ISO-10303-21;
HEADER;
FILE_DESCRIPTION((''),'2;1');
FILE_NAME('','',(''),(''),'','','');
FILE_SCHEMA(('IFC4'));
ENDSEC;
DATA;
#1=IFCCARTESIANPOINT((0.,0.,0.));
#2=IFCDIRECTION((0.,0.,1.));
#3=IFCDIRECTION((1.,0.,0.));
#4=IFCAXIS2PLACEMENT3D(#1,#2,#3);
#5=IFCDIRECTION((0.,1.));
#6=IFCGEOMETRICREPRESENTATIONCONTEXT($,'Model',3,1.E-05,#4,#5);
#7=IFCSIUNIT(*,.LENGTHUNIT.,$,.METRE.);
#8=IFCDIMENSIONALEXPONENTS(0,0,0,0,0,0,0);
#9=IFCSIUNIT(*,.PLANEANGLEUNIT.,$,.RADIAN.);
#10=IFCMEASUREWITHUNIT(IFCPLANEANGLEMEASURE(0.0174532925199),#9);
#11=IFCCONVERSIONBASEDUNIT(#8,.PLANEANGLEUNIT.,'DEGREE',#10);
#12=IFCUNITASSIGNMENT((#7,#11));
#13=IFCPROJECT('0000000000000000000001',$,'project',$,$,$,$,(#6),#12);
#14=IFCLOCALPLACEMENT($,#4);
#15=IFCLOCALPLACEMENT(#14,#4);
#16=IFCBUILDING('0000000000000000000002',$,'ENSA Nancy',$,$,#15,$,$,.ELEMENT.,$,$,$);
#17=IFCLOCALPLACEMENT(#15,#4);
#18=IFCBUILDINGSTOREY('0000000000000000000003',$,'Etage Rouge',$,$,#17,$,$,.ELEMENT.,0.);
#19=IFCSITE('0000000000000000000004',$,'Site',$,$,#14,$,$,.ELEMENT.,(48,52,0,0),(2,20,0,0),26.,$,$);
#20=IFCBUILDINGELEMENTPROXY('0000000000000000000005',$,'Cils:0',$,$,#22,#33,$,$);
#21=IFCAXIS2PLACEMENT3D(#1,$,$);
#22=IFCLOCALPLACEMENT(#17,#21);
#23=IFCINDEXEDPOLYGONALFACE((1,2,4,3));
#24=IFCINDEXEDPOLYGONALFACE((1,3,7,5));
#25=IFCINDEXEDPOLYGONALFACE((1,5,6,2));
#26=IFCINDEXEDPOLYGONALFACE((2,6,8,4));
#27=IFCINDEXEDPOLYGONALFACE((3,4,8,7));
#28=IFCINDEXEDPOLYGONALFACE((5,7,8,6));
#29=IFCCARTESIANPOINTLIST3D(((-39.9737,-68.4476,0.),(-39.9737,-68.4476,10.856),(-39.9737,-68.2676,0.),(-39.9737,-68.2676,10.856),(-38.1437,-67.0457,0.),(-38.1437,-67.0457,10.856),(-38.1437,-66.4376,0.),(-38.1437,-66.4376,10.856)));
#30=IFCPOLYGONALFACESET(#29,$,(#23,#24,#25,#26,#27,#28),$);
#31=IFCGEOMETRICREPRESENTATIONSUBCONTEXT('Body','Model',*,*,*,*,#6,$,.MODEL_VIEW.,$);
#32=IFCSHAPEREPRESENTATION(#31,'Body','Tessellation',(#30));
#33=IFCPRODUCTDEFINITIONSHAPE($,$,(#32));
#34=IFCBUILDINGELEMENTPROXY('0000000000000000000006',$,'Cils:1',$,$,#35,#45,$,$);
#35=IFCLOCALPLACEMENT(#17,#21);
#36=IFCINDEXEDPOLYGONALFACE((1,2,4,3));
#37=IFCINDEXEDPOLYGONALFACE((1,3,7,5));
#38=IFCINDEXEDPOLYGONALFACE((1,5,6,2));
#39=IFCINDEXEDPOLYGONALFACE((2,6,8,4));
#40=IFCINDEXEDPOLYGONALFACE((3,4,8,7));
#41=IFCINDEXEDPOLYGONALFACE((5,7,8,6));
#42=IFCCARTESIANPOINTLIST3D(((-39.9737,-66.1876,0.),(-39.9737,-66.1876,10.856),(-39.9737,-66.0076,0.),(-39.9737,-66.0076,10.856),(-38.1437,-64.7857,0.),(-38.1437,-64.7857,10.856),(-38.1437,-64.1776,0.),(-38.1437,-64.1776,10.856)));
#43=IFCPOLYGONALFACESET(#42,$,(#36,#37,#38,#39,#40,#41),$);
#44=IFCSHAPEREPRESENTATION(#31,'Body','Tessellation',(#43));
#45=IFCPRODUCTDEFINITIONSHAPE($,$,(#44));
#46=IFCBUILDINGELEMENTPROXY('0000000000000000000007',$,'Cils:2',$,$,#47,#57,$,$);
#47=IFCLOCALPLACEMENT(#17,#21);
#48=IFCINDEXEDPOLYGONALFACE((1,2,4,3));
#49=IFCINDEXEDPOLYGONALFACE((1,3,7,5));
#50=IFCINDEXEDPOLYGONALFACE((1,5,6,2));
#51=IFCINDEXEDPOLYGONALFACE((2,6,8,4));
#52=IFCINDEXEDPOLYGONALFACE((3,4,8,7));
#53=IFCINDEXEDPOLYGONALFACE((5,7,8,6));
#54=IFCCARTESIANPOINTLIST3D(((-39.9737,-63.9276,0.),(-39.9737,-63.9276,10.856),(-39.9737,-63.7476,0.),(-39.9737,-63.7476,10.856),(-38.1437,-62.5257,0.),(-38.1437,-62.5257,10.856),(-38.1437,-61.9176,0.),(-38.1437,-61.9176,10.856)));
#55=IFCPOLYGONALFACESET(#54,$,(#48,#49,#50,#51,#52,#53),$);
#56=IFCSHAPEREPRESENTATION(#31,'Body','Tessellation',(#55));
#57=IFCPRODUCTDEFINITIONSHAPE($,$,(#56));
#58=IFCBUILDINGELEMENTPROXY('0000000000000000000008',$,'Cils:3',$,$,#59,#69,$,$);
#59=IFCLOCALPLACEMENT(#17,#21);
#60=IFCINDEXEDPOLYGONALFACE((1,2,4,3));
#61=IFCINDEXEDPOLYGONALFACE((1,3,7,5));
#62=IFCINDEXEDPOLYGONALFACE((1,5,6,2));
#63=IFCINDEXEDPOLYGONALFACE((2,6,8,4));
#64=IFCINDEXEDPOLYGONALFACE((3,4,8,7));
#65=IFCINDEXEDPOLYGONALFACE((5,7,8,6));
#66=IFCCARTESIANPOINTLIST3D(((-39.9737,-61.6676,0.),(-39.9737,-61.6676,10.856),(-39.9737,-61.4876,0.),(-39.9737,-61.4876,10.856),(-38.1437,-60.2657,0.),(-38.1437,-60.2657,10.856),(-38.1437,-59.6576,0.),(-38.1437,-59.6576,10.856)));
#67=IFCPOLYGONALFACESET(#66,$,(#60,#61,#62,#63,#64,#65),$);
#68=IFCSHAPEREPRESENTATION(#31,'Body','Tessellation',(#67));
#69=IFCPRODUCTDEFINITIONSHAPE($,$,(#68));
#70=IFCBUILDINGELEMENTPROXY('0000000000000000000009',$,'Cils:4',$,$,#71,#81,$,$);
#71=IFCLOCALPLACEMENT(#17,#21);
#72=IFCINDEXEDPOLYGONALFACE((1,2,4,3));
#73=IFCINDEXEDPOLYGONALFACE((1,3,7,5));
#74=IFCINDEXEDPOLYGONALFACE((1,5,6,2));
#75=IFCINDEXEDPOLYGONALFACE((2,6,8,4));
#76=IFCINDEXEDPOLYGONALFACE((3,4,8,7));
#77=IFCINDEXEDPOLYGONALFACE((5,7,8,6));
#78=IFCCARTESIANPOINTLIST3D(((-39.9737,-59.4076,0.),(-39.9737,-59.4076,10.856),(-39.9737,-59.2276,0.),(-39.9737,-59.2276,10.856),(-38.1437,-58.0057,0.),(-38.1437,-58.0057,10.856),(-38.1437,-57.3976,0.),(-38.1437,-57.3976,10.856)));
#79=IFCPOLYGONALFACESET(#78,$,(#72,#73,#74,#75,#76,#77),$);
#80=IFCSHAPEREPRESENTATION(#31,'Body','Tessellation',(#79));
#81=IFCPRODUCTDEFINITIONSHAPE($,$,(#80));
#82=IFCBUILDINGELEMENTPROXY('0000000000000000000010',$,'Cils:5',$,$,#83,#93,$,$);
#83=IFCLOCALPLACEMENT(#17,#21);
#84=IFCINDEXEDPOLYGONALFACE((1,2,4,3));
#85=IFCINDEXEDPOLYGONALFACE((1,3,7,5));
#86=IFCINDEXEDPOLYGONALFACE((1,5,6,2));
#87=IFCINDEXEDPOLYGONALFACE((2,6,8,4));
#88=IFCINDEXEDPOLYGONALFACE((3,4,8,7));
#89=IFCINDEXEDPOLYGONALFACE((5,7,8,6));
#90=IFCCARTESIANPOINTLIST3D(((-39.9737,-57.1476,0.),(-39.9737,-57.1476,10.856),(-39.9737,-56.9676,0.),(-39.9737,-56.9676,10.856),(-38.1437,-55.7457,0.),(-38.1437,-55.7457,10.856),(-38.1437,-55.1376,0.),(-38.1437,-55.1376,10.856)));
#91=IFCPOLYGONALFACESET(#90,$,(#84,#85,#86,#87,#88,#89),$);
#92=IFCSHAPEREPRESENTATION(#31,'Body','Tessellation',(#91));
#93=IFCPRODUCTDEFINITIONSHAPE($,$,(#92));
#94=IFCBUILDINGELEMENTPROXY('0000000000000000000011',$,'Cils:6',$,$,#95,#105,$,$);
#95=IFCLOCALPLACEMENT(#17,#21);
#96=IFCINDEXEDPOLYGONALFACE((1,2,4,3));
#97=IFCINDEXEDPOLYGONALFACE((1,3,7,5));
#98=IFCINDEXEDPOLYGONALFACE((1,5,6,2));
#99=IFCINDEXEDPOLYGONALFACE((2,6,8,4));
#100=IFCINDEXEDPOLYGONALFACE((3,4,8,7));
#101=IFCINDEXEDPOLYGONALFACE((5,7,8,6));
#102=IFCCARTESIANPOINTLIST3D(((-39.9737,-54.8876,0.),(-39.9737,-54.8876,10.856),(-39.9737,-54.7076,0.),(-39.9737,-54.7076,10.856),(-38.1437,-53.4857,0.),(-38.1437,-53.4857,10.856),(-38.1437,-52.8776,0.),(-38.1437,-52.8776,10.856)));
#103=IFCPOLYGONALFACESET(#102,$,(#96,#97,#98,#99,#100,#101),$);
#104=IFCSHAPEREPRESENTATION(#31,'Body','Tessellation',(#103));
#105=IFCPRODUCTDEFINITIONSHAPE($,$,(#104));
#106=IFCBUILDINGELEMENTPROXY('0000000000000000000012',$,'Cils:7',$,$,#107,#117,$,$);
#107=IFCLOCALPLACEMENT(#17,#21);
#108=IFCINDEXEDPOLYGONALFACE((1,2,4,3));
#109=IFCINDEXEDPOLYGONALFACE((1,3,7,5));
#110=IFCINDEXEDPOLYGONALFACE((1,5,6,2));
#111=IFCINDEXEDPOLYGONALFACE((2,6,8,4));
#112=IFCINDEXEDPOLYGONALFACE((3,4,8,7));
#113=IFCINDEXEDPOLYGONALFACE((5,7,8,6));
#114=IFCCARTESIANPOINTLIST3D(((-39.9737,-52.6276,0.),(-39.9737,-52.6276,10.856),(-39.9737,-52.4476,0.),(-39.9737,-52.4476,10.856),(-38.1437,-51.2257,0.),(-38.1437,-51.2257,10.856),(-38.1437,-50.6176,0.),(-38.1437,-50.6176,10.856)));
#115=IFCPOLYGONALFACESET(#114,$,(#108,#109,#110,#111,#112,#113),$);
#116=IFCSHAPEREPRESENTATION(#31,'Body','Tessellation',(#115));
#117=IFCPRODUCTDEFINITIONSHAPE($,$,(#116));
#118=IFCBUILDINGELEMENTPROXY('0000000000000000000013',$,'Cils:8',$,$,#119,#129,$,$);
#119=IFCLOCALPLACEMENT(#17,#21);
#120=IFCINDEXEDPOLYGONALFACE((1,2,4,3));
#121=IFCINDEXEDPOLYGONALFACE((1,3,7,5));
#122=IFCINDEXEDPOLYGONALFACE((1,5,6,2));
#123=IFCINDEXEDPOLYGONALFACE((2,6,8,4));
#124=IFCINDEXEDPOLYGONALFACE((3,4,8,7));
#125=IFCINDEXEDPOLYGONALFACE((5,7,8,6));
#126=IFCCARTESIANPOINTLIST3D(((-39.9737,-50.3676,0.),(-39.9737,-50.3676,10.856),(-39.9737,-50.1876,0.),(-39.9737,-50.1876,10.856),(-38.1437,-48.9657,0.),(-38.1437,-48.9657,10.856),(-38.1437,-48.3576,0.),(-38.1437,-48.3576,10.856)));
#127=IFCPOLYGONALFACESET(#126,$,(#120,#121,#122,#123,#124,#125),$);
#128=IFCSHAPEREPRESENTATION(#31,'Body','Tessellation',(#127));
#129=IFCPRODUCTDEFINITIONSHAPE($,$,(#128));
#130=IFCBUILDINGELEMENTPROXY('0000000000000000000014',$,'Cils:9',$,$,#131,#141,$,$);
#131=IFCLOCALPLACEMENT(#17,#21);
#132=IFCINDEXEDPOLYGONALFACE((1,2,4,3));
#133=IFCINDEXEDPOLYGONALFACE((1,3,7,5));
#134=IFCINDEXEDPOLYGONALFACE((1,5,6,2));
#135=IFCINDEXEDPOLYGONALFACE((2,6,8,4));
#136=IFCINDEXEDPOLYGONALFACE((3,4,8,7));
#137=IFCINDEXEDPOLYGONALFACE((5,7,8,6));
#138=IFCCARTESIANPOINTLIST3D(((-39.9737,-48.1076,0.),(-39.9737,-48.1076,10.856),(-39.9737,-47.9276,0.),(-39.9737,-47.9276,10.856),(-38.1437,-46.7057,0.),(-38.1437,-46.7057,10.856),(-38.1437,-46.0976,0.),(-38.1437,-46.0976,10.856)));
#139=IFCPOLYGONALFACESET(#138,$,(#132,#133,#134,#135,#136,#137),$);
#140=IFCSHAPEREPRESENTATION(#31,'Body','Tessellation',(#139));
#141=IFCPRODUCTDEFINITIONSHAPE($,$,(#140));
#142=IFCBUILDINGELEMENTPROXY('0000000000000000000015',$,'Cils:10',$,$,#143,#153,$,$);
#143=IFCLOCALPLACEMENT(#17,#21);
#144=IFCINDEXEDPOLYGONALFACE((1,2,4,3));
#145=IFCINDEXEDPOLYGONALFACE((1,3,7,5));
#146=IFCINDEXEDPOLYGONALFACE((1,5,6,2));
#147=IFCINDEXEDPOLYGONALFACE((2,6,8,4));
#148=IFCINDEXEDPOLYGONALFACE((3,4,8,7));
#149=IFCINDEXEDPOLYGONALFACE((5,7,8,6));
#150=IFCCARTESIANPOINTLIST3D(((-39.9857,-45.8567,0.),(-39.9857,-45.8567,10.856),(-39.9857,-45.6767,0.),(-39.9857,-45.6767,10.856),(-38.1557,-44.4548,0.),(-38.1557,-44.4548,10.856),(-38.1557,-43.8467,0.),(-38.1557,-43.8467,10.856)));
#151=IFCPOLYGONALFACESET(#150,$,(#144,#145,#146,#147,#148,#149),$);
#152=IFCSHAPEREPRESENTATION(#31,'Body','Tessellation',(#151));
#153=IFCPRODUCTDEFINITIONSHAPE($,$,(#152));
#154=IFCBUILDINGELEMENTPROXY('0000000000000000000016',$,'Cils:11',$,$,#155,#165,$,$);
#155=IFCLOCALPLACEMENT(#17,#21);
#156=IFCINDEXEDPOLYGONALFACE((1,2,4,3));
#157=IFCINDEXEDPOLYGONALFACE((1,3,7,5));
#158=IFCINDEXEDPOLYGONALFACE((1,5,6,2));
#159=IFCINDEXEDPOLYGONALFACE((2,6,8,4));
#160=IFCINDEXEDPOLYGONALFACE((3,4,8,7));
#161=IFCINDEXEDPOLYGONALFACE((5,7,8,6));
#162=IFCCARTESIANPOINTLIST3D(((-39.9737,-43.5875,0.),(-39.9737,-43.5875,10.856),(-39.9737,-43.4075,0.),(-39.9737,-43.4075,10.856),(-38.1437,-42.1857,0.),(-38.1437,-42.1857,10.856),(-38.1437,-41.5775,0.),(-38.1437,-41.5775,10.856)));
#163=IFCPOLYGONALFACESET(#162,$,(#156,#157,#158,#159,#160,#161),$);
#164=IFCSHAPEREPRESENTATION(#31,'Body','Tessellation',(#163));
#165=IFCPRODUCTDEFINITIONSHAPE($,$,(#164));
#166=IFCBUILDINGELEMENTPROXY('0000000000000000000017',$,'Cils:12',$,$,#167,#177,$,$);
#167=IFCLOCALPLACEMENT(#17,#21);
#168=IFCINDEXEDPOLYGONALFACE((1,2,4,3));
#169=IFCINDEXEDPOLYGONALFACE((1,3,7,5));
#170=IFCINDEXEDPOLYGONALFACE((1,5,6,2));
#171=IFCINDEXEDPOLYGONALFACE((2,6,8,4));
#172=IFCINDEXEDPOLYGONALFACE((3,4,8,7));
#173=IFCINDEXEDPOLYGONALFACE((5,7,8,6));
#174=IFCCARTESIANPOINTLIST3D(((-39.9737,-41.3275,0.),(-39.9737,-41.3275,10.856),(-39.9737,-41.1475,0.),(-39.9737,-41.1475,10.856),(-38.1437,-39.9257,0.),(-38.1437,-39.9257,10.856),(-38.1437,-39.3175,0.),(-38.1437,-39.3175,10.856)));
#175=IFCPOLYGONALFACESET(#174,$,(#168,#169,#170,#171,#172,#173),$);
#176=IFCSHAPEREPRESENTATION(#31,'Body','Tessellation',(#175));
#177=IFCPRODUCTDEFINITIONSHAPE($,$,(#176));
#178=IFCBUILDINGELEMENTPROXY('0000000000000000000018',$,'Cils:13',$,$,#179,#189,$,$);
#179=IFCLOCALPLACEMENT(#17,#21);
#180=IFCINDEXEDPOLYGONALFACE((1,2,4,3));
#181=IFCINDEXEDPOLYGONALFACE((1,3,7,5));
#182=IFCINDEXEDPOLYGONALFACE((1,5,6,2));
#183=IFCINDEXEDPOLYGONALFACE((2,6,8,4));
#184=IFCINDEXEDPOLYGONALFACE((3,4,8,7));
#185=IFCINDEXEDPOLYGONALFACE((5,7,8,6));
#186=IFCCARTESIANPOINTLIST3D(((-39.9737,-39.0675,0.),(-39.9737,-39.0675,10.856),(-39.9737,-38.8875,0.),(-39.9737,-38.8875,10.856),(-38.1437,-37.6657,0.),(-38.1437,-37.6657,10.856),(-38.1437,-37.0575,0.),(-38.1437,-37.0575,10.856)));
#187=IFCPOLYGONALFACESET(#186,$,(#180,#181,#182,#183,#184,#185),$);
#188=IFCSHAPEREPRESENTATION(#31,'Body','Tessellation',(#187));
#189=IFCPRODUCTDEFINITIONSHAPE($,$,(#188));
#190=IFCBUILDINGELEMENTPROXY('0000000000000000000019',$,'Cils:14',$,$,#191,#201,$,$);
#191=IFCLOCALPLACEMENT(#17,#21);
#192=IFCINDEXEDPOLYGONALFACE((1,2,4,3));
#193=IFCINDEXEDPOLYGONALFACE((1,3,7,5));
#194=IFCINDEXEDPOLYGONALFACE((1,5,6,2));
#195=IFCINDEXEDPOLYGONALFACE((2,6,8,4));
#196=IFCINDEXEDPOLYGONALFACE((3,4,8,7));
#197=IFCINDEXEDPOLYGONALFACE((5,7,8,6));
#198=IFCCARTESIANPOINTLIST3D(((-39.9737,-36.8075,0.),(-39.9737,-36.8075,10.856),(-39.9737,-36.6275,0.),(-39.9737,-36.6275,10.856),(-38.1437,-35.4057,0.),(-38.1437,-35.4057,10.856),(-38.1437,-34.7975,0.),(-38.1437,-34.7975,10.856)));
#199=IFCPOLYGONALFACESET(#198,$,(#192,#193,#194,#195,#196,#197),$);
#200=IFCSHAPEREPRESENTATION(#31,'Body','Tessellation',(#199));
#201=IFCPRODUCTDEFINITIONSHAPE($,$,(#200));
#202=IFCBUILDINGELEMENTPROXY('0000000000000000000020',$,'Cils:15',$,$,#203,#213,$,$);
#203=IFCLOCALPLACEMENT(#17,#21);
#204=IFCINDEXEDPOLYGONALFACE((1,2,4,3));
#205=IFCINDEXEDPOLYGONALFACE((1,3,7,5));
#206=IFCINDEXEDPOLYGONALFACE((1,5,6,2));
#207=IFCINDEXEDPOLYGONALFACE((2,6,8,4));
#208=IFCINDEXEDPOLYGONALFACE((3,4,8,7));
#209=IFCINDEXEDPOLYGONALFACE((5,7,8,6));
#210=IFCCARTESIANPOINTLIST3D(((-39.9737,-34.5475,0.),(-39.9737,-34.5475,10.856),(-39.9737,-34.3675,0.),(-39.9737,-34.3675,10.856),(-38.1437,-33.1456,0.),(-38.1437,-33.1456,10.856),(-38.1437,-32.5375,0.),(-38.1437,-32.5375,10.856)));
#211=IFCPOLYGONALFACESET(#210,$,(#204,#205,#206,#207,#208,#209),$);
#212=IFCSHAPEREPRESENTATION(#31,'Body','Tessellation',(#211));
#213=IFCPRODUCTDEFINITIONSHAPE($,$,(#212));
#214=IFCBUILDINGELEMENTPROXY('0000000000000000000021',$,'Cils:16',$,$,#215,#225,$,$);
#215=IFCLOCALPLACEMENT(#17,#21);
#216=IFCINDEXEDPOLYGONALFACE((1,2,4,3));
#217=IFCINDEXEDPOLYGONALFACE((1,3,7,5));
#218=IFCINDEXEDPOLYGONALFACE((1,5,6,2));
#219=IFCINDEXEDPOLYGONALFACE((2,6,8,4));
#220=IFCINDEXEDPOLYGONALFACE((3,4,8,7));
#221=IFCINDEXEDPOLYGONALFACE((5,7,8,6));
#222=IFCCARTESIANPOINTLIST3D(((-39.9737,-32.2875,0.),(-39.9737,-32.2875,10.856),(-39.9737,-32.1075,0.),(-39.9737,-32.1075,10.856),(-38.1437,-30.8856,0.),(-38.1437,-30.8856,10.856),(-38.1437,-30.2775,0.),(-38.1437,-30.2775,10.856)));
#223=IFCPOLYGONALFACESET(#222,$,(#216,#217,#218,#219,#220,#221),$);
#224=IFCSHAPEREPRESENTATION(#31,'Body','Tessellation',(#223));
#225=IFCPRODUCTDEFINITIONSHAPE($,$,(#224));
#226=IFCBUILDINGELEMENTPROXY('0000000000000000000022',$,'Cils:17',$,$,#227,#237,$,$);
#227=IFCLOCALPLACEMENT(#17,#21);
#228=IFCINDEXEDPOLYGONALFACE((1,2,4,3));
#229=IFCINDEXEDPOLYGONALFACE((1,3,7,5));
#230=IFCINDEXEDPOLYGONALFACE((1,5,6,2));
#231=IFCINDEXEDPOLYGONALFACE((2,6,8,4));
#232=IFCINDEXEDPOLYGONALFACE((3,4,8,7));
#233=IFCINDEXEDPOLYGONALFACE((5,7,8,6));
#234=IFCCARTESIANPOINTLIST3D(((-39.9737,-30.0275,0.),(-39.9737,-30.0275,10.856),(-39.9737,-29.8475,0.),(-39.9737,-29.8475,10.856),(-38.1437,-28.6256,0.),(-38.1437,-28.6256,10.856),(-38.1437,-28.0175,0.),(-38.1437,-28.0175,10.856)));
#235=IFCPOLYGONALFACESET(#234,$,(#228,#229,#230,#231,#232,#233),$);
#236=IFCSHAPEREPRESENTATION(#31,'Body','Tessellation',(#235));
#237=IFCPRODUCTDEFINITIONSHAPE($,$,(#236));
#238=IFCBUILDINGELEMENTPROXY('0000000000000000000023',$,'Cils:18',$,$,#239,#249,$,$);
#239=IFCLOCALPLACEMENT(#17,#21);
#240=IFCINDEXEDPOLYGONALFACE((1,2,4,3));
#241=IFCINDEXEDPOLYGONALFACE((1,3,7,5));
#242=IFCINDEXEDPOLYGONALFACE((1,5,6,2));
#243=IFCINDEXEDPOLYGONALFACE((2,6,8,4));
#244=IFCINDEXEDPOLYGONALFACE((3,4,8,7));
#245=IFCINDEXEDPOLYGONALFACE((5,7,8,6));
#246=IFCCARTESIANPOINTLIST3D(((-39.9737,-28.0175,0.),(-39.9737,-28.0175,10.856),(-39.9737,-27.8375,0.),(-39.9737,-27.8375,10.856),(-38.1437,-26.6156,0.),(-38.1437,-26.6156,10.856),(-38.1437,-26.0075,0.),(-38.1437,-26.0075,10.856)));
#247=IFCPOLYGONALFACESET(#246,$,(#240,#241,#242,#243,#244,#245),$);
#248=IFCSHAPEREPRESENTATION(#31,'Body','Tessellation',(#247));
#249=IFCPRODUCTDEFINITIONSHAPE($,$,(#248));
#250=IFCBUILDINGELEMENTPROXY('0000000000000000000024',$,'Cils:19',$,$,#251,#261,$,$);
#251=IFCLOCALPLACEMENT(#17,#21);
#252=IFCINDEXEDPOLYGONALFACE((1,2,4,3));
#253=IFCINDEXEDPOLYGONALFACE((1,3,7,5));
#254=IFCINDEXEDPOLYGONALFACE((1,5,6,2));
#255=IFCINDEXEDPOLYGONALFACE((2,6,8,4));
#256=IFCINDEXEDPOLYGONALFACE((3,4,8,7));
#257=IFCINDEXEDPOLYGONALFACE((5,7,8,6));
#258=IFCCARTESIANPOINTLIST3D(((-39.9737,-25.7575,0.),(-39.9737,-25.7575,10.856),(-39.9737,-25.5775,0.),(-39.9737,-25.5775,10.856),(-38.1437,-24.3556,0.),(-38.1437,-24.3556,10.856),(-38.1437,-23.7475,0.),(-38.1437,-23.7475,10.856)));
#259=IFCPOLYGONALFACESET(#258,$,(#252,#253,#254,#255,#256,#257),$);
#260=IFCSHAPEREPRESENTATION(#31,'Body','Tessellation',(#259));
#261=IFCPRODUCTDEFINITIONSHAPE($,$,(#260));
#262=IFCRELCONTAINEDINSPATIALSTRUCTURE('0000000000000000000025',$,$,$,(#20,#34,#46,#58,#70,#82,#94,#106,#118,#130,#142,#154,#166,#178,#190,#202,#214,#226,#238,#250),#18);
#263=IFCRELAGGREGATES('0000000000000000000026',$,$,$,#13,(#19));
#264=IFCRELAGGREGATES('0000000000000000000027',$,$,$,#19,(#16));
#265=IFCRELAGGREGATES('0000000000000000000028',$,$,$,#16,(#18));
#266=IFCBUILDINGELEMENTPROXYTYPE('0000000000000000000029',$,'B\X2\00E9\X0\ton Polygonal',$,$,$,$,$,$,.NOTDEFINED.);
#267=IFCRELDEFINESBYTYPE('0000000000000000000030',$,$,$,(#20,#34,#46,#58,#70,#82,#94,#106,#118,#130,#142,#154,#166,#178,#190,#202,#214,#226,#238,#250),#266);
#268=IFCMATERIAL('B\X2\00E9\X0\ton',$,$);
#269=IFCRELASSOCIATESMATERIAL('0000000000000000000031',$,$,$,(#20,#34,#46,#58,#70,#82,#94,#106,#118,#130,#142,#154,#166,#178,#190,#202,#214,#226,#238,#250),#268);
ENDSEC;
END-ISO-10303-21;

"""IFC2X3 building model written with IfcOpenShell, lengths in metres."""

from ifc_helpers import new_model, entity, si_unit, converted_unit, direction, frame, origin_with_axes, place, context, subcontext, project, spatial, polyline, outline, extrude, material, type_object, element, save


model = new_model("IFC2X3")

# Units and contexts
model_context = context("Model", 3, precision=1e-05, world=origin_with_axes(), true_north=direction((0.0, 1.0)))
body_context = subcontext(model_context, "Body", "Model", "MODEL_VIEW")
ifc_project = project(units=[si_unit("LENGTHUNIT", "METRE"), converted_unit("PLANEANGLEUNIT", "DEGREE", entity("IfcPlaneAngleMeasure", 0.0174532925199), si_unit("PLANEANGLEUNIT", "RADIAN"), dimensions=[0, 0, 0, 0, 0, 0, 0])], contexts=[model_context])

# Site, building, storey
site_placement = place(None, origin_with_axes())
site = spatial("IfcSite", under=ifc_project, at=site_placement, Name="Site", CompositionType="ELEMENT", RefLatitude=(48, 52, 0, 0), RefLongitude=(2, 20, 0, 0), RefElevation=26.0)
building_placement = place(site_placement, origin_with_axes())
building = spatial("IfcBuilding", under=site, at=building_placement, Name="ENSA Nancy", CompositionType="ELEMENT")
storey_placement = place(building_placement, origin_with_axes())
storey = spatial("IfcBuildingStorey", under=building, at=storey_placement, Name="Etage Rouge", CompositionType="ELEMENT", Elevation=0.0)

# Building element proxies
ifc_material = material(Name="Béton")
building_element_proxy_type = type_object("IfcBuildingElementProxyType", Name="Béton Polygonal", PredefinedType="NOTDEFINED")
for number, where, z_axis, x_axis, name in (
    (1, (-38.1437, -66.4376, 0.0), (0.0, 0.0, 1.0), (-0.707107, -0.707107, 0.0), "Cils:0"),
    (2, (-38.1437, -64.1776, 0.0), (0.0, 0.0, 1.0), (-0.707107, -0.707107, 0.0), "Cils:1"),
    (3, (-38.1437, -61.9176, 0.0), (0.0, 0.0, 1.0), (-0.707107, -0.707107, 0.0), "Cils:2"),
    (4, (-38.1437, -59.6576, 0.0), (0.0, 0.0, 1.0), (-0.707107, -0.707107, 0.0), "Cils:3"),
    (5, (-38.1437, -57.3976, 0.0), (0.0, 0.0, 1.0), (-0.707107, -0.707107, 0.0), "Cils:4"),
    (6, (-38.1437, -55.1376, 0.0), (0.0, 0.0, 1.0), (-0.707107, -0.707107, 0.0), "Cils:5"),
    (7, (-38.1437, -52.8776, 0.0), (0.0, 0.0, 1.0), (-0.707107, -0.707107, 0.0), "Cils:6"),
    (8, (-38.1437, -50.6176, 0.0), (0.0, 0.0, 1.0), (-0.707107, -0.707107, 0.0), "Cils:7"),
    (9, (-38.1437, -48.3576, 0.0), (0.0, 0.0, 1.0), (-0.707107, -0.707107, 0.0), "Cils:8"),
    (10, (-38.1437, -46.0976, 0.0), (0.0, 0.0, 1.0), (-0.707107, -0.707107, 0.0), "Cils:9"),
    (11, (-38.1557, -43.8467, 0.0), (0.0, 0.0, 1.0), (-0.707107, -0.707107, 0.0), "Cils:10"),
    (12, (-38.1437, -41.5775, 0.0), (0.0, 0.0, 1.0), (-0.707107, -0.707107, 0.0), "Cils:11"),
    (13, (-38.1437, -39.3175, 0.0), (0.0, 0.0, 1.0), (-0.707107, -0.707107, 0.0), "Cils:12"),
    (14, (-38.1437, -37.0575, 0.0), (0.0, 0.0, 1.0), (-0.707107, -0.707107, 0.0), "Cils:13"),
    (15, (-38.1437, -34.7975, 0.0), (0.0, 0.0, 1.0), (-0.707107, -0.707107, 0.0), "Cils:14"),
    (16, (-38.1437, -32.5375, 0.0), (0.0, 0.0, 1.0), (-0.707107, -0.707107, 0.0), "Cils:15"),
    (17, (-38.1437, -30.2775, 0.0), (0.0, 0.0, 1.0), (-0.707107, -0.707107, 0.0), "Cils:16"),
    (18, (-38.1437, -28.0175, 0.0), (0.0, 0.0, 1.0), (-0.707107, -0.707107, 0.0), "Cils:17"),
    (19, (-38.1437, -26.0075, 0.0), (0.0, 0.0, 1.0), (-0.707107, -0.707107, 0.0), "Cils:18"),
    (20, (-38.1437, -23.7475, 0.0), (0.0, 0.0, 1.0), (-0.707107, -0.707107, 0.0), "Cils:19"),
):
    element("IfcBuildingElementProxy", number, at=place(storey_placement, frame(where, z_axis=z_axis, x_axis=x_axis)), inside=storey, type_object=building_element_proxy_type, material=ifc_material, Name=name, context=body_context, shape_type="SweptSolid", body=[
        extrude(outline(polyline([(0.0, 0.0), (2.588, 0.0), (2.7153, 0.1273), (0.43, 0.43), (0.0, 0.0)])), origin_with_axes(), (0.0, 0.0, 1.0), 10.856),
    ])

save(model, "model.ifc")
